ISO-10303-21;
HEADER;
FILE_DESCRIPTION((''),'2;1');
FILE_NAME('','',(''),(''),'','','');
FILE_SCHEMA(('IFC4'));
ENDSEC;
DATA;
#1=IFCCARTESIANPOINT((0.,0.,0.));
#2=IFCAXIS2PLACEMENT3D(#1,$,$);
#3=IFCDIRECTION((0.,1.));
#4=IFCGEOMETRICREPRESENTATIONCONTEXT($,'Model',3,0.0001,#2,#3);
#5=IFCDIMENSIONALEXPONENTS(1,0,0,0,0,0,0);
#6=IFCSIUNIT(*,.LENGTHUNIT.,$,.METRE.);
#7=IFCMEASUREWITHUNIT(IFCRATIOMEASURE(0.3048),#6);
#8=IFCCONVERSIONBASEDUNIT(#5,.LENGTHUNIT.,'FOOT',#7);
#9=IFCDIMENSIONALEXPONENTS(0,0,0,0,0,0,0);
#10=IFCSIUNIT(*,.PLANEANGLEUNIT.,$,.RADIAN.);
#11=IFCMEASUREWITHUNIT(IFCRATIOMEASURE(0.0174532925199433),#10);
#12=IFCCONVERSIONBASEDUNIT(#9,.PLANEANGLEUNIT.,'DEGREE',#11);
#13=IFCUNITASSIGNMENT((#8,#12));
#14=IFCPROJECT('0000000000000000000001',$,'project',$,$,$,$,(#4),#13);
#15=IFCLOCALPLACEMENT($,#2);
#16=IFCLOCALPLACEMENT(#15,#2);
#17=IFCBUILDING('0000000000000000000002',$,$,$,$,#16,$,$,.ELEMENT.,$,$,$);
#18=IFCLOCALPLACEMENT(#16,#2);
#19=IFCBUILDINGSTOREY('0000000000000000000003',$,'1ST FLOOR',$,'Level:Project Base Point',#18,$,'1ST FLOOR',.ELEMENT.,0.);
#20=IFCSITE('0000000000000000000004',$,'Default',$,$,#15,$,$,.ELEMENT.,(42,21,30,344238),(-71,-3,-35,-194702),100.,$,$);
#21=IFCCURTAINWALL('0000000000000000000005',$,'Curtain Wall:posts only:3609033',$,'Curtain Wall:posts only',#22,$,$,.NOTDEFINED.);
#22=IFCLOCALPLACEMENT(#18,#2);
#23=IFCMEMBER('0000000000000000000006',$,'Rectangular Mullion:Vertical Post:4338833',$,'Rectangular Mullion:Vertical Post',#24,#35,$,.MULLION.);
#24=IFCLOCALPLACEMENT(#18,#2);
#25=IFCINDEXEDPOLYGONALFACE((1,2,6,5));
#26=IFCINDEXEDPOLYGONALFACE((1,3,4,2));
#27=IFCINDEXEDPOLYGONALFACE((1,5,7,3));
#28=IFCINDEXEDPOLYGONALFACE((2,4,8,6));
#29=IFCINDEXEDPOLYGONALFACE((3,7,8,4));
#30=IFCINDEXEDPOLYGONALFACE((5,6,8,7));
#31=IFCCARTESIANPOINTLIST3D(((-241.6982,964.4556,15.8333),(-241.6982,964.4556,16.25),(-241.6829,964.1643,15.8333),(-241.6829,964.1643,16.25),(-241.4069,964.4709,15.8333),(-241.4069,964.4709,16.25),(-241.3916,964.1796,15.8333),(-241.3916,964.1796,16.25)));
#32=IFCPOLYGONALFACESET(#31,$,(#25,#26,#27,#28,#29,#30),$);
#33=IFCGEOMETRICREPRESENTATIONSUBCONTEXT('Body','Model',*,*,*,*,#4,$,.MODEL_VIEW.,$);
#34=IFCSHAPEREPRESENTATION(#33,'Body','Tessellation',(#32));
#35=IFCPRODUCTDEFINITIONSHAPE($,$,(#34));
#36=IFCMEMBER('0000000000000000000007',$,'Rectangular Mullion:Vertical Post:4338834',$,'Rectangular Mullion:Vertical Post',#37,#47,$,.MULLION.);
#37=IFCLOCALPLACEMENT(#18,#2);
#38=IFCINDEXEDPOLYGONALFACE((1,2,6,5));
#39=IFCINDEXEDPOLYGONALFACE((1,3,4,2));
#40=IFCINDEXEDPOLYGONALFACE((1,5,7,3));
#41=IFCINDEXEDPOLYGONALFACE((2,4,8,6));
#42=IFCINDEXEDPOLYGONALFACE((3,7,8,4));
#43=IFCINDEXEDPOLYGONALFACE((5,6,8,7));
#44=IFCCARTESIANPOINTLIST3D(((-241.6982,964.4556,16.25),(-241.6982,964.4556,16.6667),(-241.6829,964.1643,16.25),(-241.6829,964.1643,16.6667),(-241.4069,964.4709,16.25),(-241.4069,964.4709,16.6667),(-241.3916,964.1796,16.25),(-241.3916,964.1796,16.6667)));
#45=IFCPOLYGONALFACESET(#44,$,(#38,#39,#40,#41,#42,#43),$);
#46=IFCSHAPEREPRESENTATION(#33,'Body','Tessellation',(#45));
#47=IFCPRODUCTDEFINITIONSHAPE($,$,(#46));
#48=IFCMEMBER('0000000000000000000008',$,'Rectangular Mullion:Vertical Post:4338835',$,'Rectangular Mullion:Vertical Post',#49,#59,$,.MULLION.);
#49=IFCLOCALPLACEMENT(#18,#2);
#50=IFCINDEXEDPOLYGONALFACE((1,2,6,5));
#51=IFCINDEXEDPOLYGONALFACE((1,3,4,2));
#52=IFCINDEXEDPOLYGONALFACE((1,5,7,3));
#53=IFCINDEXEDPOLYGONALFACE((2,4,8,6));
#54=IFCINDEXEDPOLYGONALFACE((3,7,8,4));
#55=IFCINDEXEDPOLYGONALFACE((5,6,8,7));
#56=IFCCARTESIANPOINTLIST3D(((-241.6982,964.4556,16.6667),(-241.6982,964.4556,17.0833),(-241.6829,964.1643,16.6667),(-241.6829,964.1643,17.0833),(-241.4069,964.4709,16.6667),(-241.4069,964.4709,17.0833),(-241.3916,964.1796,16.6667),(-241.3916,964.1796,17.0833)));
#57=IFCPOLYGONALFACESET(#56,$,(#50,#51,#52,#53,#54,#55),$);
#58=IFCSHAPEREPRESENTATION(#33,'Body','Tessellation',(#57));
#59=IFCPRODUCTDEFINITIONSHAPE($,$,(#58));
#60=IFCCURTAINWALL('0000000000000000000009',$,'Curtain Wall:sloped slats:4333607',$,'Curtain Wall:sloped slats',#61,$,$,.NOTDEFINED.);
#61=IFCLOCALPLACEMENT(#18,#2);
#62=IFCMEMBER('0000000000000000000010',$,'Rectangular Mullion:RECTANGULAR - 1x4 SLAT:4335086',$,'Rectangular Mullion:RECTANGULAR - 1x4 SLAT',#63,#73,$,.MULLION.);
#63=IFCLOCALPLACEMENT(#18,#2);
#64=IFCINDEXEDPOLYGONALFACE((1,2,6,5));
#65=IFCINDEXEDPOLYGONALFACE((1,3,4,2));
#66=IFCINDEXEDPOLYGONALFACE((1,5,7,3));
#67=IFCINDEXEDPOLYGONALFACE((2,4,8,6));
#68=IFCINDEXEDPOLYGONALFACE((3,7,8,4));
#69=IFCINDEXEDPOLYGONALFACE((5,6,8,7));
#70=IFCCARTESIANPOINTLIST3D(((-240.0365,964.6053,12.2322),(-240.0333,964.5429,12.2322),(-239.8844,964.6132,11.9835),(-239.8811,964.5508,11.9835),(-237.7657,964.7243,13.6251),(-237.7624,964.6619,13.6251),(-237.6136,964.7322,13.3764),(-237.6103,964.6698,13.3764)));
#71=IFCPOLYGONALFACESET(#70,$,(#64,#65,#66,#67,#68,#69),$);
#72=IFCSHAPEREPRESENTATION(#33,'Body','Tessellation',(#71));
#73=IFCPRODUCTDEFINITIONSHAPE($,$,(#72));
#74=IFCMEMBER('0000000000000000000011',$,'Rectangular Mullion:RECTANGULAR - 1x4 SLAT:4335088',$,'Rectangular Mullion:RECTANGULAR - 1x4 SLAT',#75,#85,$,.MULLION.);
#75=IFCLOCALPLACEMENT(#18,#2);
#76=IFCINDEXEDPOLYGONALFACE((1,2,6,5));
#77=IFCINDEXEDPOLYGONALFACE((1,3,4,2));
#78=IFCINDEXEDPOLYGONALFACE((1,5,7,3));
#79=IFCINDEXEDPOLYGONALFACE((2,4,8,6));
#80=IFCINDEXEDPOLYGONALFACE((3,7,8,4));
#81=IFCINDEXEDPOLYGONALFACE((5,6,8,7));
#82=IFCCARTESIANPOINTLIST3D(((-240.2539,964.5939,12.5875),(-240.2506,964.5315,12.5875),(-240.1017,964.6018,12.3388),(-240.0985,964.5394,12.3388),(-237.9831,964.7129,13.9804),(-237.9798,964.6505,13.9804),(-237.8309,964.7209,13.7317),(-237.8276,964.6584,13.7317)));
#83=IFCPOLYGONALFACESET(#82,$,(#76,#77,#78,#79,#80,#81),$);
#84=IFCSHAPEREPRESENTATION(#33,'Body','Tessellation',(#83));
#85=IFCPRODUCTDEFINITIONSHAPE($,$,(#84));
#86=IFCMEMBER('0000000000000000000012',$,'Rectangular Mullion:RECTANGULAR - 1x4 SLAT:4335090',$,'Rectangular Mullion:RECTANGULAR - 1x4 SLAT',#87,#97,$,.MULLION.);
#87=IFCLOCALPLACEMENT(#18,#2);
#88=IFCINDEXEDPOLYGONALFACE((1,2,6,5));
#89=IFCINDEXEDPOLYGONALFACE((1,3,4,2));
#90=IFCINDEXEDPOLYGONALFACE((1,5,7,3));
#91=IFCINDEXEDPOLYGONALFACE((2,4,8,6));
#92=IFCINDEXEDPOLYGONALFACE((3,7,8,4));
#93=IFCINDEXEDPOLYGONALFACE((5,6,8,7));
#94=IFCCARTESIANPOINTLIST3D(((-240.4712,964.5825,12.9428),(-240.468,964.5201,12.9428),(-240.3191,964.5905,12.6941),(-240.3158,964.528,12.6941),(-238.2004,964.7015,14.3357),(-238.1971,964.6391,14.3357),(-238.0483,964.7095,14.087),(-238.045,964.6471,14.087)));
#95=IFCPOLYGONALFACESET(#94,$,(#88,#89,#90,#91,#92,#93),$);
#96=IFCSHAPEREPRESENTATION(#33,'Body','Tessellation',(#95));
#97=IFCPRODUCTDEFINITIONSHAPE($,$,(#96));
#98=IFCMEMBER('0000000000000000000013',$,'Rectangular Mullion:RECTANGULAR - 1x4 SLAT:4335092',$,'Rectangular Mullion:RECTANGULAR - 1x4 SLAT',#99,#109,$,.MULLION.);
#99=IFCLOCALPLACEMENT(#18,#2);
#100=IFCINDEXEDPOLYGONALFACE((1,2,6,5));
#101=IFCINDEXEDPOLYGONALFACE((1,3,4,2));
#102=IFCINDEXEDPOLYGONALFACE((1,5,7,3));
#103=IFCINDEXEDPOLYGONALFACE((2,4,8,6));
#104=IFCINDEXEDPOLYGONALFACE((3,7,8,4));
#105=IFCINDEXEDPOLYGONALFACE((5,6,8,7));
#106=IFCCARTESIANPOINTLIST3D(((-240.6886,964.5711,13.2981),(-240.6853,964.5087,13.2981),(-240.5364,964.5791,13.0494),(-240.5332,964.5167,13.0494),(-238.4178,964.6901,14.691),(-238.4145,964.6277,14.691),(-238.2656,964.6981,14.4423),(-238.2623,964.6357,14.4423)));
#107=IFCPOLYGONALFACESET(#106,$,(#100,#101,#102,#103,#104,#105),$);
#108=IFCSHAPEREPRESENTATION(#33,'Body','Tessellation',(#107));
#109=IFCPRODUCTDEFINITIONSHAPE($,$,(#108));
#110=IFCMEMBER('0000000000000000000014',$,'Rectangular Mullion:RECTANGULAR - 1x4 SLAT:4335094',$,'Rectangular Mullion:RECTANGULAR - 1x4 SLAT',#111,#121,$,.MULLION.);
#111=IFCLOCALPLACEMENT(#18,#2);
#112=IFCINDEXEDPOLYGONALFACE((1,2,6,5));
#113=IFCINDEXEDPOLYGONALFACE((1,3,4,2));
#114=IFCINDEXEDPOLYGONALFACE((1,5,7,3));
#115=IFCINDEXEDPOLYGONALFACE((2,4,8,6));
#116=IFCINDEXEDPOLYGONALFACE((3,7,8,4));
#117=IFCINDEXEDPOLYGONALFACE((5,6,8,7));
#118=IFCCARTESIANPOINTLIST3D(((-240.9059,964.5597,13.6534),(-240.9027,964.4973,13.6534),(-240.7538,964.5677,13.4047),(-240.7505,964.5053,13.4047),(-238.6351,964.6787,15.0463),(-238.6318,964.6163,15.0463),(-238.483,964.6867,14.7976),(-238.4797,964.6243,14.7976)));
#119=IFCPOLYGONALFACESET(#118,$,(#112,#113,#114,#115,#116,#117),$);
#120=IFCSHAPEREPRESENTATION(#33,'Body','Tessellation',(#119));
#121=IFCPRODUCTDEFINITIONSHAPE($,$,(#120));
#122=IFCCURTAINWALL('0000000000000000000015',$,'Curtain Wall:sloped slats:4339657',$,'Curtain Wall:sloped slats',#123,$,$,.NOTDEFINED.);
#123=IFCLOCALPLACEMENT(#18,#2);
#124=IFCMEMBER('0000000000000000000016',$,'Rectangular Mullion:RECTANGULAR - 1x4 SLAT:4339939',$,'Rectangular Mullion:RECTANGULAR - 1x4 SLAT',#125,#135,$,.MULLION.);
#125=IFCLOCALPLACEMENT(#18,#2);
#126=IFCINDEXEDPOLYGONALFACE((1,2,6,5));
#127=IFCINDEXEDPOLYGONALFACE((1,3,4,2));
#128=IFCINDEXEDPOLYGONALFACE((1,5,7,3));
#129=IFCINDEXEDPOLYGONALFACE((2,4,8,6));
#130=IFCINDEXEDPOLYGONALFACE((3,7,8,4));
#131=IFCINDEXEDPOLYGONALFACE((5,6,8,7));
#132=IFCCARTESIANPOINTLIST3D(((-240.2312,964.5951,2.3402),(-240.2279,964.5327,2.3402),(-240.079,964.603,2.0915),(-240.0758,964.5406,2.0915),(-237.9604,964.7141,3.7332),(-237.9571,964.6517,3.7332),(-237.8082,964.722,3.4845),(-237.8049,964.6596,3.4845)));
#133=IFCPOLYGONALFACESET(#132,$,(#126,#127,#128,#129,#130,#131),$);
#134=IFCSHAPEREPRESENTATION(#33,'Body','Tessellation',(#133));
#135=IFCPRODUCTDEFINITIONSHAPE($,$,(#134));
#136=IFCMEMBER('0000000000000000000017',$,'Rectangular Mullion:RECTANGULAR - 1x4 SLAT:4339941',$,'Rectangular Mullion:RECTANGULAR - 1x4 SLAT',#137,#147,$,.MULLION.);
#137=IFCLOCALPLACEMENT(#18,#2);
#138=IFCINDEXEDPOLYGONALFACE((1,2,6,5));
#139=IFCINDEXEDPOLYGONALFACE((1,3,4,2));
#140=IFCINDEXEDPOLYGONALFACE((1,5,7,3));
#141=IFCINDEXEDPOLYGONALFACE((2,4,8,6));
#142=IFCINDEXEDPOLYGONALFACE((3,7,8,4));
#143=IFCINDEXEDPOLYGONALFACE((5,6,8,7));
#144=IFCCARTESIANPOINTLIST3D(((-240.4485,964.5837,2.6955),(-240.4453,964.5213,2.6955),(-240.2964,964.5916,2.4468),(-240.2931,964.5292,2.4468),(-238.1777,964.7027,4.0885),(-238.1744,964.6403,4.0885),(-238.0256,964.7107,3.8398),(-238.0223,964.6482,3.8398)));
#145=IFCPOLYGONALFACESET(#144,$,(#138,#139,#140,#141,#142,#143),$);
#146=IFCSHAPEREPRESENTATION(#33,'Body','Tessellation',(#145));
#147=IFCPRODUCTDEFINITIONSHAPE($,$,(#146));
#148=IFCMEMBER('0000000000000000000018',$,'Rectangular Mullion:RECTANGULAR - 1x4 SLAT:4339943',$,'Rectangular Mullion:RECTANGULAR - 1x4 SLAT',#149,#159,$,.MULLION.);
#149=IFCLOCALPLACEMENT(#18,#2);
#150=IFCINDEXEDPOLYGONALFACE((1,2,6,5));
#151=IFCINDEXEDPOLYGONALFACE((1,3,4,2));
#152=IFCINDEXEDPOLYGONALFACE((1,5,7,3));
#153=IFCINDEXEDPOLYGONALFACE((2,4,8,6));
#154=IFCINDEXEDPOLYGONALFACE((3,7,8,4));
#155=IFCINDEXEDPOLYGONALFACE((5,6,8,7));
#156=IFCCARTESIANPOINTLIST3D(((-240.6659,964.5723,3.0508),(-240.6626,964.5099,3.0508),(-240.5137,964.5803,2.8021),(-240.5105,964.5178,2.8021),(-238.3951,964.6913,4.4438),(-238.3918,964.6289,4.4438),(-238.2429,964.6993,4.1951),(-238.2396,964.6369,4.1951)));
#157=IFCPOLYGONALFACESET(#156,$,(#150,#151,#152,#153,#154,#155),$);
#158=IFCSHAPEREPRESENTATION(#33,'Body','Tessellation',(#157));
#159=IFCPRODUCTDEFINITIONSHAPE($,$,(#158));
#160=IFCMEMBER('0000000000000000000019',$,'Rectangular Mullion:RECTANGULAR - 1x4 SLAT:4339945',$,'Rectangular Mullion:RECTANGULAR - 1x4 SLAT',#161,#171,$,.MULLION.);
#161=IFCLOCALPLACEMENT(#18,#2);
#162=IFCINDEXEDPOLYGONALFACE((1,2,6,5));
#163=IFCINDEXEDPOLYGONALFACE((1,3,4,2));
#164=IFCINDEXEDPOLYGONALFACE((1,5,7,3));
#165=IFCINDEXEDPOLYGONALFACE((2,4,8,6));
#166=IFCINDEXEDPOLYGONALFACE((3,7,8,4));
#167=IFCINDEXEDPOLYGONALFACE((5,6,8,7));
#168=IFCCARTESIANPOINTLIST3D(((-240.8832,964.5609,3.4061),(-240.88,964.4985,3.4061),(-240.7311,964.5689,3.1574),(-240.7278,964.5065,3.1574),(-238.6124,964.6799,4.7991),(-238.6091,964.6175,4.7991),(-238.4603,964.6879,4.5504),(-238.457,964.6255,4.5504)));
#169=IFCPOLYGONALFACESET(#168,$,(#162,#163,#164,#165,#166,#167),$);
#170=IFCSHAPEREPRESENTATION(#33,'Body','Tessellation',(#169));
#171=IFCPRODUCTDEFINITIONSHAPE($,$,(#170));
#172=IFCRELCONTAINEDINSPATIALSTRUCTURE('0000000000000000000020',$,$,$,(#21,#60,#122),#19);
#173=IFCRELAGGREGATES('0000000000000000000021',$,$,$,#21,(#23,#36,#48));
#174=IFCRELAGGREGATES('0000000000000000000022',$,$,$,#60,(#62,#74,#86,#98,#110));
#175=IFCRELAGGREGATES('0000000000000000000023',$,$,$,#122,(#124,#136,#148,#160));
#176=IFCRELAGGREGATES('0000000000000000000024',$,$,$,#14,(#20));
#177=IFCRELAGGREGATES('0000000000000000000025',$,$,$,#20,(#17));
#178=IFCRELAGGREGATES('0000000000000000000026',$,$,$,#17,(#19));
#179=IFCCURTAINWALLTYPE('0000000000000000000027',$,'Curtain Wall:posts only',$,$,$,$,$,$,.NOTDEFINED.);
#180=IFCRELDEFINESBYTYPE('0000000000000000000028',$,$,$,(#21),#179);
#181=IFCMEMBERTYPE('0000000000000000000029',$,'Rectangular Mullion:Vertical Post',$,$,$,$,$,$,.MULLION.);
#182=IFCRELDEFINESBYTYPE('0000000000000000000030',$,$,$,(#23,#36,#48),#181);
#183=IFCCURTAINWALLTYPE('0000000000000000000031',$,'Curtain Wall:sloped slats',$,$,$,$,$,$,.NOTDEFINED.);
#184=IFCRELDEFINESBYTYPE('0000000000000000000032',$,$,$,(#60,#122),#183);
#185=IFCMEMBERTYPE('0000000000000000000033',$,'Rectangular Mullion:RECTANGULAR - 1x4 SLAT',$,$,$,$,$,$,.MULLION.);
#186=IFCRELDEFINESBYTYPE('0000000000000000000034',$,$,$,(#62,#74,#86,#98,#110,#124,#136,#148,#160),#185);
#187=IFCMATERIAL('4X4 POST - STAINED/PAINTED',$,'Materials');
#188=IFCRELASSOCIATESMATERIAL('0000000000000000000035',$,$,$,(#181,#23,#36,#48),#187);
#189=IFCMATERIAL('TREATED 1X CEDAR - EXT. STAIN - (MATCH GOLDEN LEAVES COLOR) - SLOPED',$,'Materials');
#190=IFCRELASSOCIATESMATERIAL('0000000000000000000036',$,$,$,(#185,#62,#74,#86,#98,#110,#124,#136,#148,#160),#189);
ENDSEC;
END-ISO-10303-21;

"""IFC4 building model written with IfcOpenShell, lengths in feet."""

from ifc_helpers import new_model, entity, si_unit, converted_unit, direction, frame, frame_2d, origin, origin_2d_with_axis, place, context, subcontext, project, spatial, rectangle, extrude, source, transform, mapped, material, material_profile, profile_set, profile_usage, type_object, type_shapes, element, aggregate, save


model = new_model("IFC4")

# Units and contexts
model_context = context("Model", 3, precision=0.0001, world=origin(), true_north=direction((0.0, 1.0)))
body_context = subcontext(model_context, "Body", "Model", "MODEL_VIEW")
ifc_project = project(units=[converted_unit("LENGTHUNIT", "FOOT", entity("IfcRatioMeasure", 0.3048), si_unit("LENGTHUNIT", "METRE"), dimensions=[1, 0, 0, 0, 0, 0, 0]), converted_unit("PLANEANGLEUNIT", "DEGREE", entity("IfcRatioMeasure", 0.0174532925199433), si_unit("PLANEANGLEUNIT", "RADIAN"), dimensions=[0, 0, 0, 0, 0, 0, 0])], contexts=[model_context])

# Site, building, storey
site_placement = place(None, origin())
site = spatial("IfcSite", under=ifc_project, at=site_placement, Name="Default", CompositionType="ELEMENT", RefLatitude=(42, 21, 30, 344238), RefLongitude=(-71, -3, -35, -194702), RefElevation=100.0)
building_placement = place(site_placement, origin())
building = spatial("IfcBuilding", under=site, at=building_placement, CompositionType="ELEMENT")
storey_placement = place(building_placement, origin())
storey = spatial("IfcBuildingStorey", under=building, at=storey_placement, Name="1ST FLOOR", ObjectType="Level:Project Base Point", LongName="1ST FLOOR", CompositionType="ELEMENT", Elevation=0.0)

# Curtain walls, members
curtain_wall_type_1 = type_object("IfcCurtainWallType", Name="Curtain Wall:posts only", PredefinedType="NOTDEFINED")
curtain_wall_1_placement = place(storey_placement, origin())
curtain_wall_1 = element("IfcCurtainWall", 1, at=curtain_wall_1_placement, inside=storey, type_object=curtain_wall_type_1, Name="Curtain Wall:posts only:3609033", ObjectType="Curtain Wall:posts only", PredefinedType="NOTDEFINED")
ifc_material_1 = material(Name="4X4 POST - STAINED/PAINTED", Category="Materials")
ifc_material_profile_1 = material_profile(ifc_material_1, rectangle(XDim=0.2917, YDim=0.2917, at=origin_2d_with_axis()), Name="Vertical Post")
ifc_profile_set_1 = profile_set([ifc_material_profile_1], Name="Vertical Post")
member_type_1 = type_object("IfcMemberType", Name="Rectangular Mullion:Vertical Post", PredefinedType="MULLION", material=ifc_profile_set_1)
shared_shape_1 = source(origin(), body_context, "Body", "SweptSolid", [
    extrude(rectangle(XDim=0.2917, YDim=0.2917, at=origin_2d_with_axis()), frame((0.0, -0.2083, -0.4167), z_axis=(0.0, 0.0, 1.0), x_axis=(0.0, -1.0, 0.0)), (0.0, 0.0, 1.0), 0.4167),
])
type_shapes(member_type_1, [shared_shape_1])
ifc_profile_usage_1 = profile_usage(ifc_profile_set_1)
member_1_placement = place(storey_placement, frame((-241.5558, 964.5256, 15.8333), z_axis=(0.0, 0.0, -1.0), x_axis=(-0.99863, -0.052336, 0.0)))
member_1 = element("IfcMember", 2, at=member_1_placement, type_object=member_type_1, material=ifc_profile_usage_1, Name="Rectangular Mullion:Vertical Post:4338833", ObjectType="Rectangular Mullion:Vertical Post", PredefinedType="MULLION", context=body_context, shape_type="MappedRepresentation", body=[
    mapped(shared_shape_1, transform((0.0, 0.0, 0.0), scale=1.0)),
])
ifc_profile_usage_2 = profile_usage(ifc_profile_set_1)
member_2_placement = place(storey_placement, frame((-241.5558, 964.5256, 16.25), z_axis=(0.0, 0.0, -1.0), x_axis=(-0.99863, -0.052336, 0.0)))
member_2 = element("IfcMember", 3, at=member_2_placement, type_object=member_type_1, material=ifc_profile_usage_2, Name="Rectangular Mullion:Vertical Post:4338834", ObjectType="Rectangular Mullion:Vertical Post", PredefinedType="MULLION", context=body_context, shape_type="MappedRepresentation", body=[
    mapped(shared_shape_1, transform((0.0, 0.0, 0.0), scale=1.0)),
])
ifc_profile_usage_3 = profile_usage(ifc_profile_set_1)
member_3_placement = place(storey_placement, frame((-241.5558, 964.5256, 16.6667), z_axis=(0.0, 0.0, -1.0), x_axis=(-0.99863, -0.052336, 0.0)))
member_3 = element("IfcMember", 4, at=member_3_placement, type_object=member_type_1, material=ifc_profile_usage_3, Name="Rectangular Mullion:Vertical Post:4338835", ObjectType="Rectangular Mullion:Vertical Post", PredefinedType="MULLION", context=body_context, shape_type="MappedRepresentation", body=[
    mapped(shared_shape_1, transform((0.0, 0.0, 0.0), scale=1.0)),
])
aggregate(curtain_wall_1, [member_1, member_2, member_3])
curtain_wall_type_2 = type_object("IfcCurtainWallType", Name="Curtain Wall:sloped slats", PredefinedType="NOTDEFINED")
curtain_wall_2_placement = place(storey_placement, origin())
curtain_wall_2 = element("IfcCurtainWall", 5, at=curtain_wall_2_placement, inside=storey, type_object=curtain_wall_type_2, Name="Curtain Wall:sloped slats:4333607", ObjectType="Curtain Wall:sloped slats", PredefinedType="NOTDEFINED")
ifc_material_2 = material(Name="TREATED 1X CEDAR - EXT. STAIN - (MATCH GOLDEN LEAVES COLOR) - SLOPED", Category="Materials")
ifc_material_profile_2 = material_profile(ifc_material_2, rectangle(XDim=0.0625, YDim=0.2917, at=frame_2d((0.0, 0.0), x_axis=(1.0, 0.0))), Name="RECTANGULAR - 1x4 SLAT")
ifc_profile_set_2 = profile_set([ifc_material_profile_2], Name="RECTANGULAR - 1x4 SLAT")
ifc_profile_usage_4 = profile_usage(ifc_profile_set_2)
member_type_2 = type_object("IfcMemberType", Name="Rectangular Mullion:RECTANGULAR - 1x4 SLAT", PredefinedType="MULLION", material=ifc_profile_set_2)
shared_shape_2 = source(origin(), body_context, "Body", "SweptSolid", [
    extrude(rectangle(XDim=0.0625, YDim=0.2917, at=frame_2d((0.0, 0.0), x_axis=(1.0, 0.0))), frame((0.0, 0.0, -2.6667), z_axis=(0.0, 0.0, 1.0), x_axis=(0.0, -1.0, 0.0)), (0.0, 0.0, 1.0), 2.6667),
])
type_shapes(member_type_2, [shared_shape_2])
member_4_placement = place(storey_placement, frame((-239.9588, 964.578, 12.1078), z_axis=(-0.851559, -0.044628, -0.522356), x_axis=(-0.52164, -0.027338, 0.852727)))
member_4 = element("IfcMember", 6, at=member_4_placement, type_object=member_type_2, material=ifc_profile_usage_4, Name="Rectangular Mullion:RECTANGULAR - 1x4 SLAT:4335086", ObjectType="Rectangular Mullion:RECTANGULAR - 1x4 SLAT", PredefinedType="MULLION", context=body_context, shape_type="MappedRepresentation", body=[
    mapped(shared_shape_2, transform((0.0, 0.0, 0.0), scale=1.0)),
])
ifc_profile_usage_5 = profile_usage(ifc_profile_set_2)
member_5_placement = place(storey_placement, frame((-240.1762, 964.5667, 12.4631), z_axis=(-0.851559, -0.044628, -0.522356), x_axis=(-0.52164, -0.027338, 0.852727)))
member_5 = element("IfcMember", 7, at=member_5_placement, type_object=member_type_2, material=ifc_profile_usage_5, Name="Rectangular Mullion:RECTANGULAR - 1x4 SLAT:4335088", ObjectType="Rectangular Mullion:RECTANGULAR - 1x4 SLAT", PredefinedType="MULLION", context=body_context, shape_type="MappedRepresentation", body=[
    mapped(shared_shape_2, transform((0.0, 0.0, 0.0), scale=1.0)),
])
ifc_profile_usage_6 = profile_usage(ifc_profile_set_2)
member_6_placement = place(storey_placement, frame((-240.3935, 964.5553, 12.8184), z_axis=(-0.851559, -0.044628, -0.522356), x_axis=(-0.52164, -0.027338, 0.852727)))
member_6 = element("IfcMember", 8, at=member_6_placement, type_object=member_type_2, material=ifc_profile_usage_6, Name="Rectangular Mullion:RECTANGULAR - 1x4 SLAT:4335090", ObjectType="Rectangular Mullion:RECTANGULAR - 1x4 SLAT", PredefinedType="MULLION", context=body_context, shape_type="MappedRepresentation", body=[
    mapped(shared_shape_2, transform((0.0, 0.0, 0.0), scale=1.0)),
])
ifc_profile_usage_7 = profile_usage(ifc_profile_set_2)
member_7_placement = place(storey_placement, frame((-240.6109, 964.5439, 13.1737), z_axis=(-0.851559, -0.044628, -0.522356), x_axis=(-0.52164, -0.027338, 0.852727)))
member_7 = element("IfcMember", 9, at=member_7_placement, type_object=member_type_2, material=ifc_profile_usage_7, Name="Rectangular Mullion:RECTANGULAR - 1x4 SLAT:4335092", ObjectType="Rectangular Mullion:RECTANGULAR - 1x4 SLAT", PredefinedType="MULLION", context=body_context, shape_type="MappedRepresentation", body=[
    mapped(shared_shape_2, transform((0.0, 0.0, 0.0), scale=1.0)),
])
ifc_profile_usage_8 = profile_usage(ifc_profile_set_2)
member_8_placement = place(storey_placement, frame((-240.8282, 964.5325, 13.529), z_axis=(-0.851559, -0.044628, -0.522356), x_axis=(-0.52164, -0.027338, 0.852727)))
member_8 = element("IfcMember", 10, at=member_8_placement, type_object=member_type_2, material=ifc_profile_usage_8, Name="Rectangular Mullion:RECTANGULAR - 1x4 SLAT:4335094", ObjectType="Rectangular Mullion:RECTANGULAR - 1x4 SLAT", PredefinedType="MULLION", context=body_context, shape_type="MappedRepresentation", body=[
    mapped(shared_shape_2, transform((0.0, 0.0, 0.0), scale=1.0)),
])
aggregate(curtain_wall_2, [member_4, member_5, member_6, member_7, member_8])
curtain_wall_3_placement = place(storey_placement, origin())
curtain_wall_3 = element("IfcCurtainWall", 11, at=curtain_wall_3_placement, inside=storey, type_object=curtain_wall_type_2, Name="Curtain Wall:sloped slats:4339657", ObjectType="Curtain Wall:sloped slats", PredefinedType="NOTDEFINED")
ifc_profile_usage_9 = profile_usage(ifc_profile_set_2)
member_9_placement = place(storey_placement, frame((-240.1535, 964.5678, 2.2159), z_axis=(-0.851559, -0.044628, -0.522356), x_axis=(-0.52164, -0.027338, 0.852727)))
member_9 = element("IfcMember", 12, at=member_9_placement, type_object=member_type_2, material=ifc_profile_usage_9, Name="Rectangular Mullion:RECTANGULAR - 1x4 SLAT:4339939", ObjectType="Rectangular Mullion:RECTANGULAR - 1x4 SLAT", PredefinedType="MULLION", context=body_context, shape_type="MappedRepresentation", body=[
    mapped(shared_shape_2, transform((0.0, 0.0, 0.0), scale=1.0)),
])
ifc_profile_usage_10 = profile_usage(ifc_profile_set_2)
member_10_placement = place(storey_placement, frame((-240.3708, 964.5565, 2.5712), z_axis=(-0.851559, -0.044628, -0.522356), x_axis=(-0.52164, -0.027338, 0.852727)))
member_10 = element("IfcMember", 13, at=member_10_placement, type_object=member_type_2, material=ifc_profile_usage_10, Name="Rectangular Mullion:RECTANGULAR - 1x4 SLAT:4339941", ObjectType="Rectangular Mullion:RECTANGULAR - 1x4 SLAT", PredefinedType="MULLION", context=body_context, shape_type="MappedRepresentation", body=[
    mapped(shared_shape_2, transform((0.0, 0.0, 0.0), scale=1.0)),
])
ifc_profile_usage_11 = profile_usage(ifc_profile_set_2)
member_11_placement = place(storey_placement, frame((-240.5882, 964.5451, 2.9265), z_axis=(-0.851559, -0.044628, -0.522356), x_axis=(-0.52164, -0.027338, 0.852727)))
member_11 = element("IfcMember", 14, at=member_11_placement, type_object=member_type_2, material=ifc_profile_usage_11, Name="Rectangular Mullion:RECTANGULAR - 1x4 SLAT:4339943", ObjectType="Rectangular Mullion:RECTANGULAR - 1x4 SLAT", PredefinedType="MULLION", context=body_context, shape_type="MappedRepresentation", body=[
    mapped(shared_shape_2, transform((0.0, 0.0, 0.0), scale=1.0)),
])
ifc_profile_usage_12 = profile_usage(ifc_profile_set_2)
member_12_placement = place(storey_placement, frame((-240.8055, 964.5337, 3.2818), z_axis=(-0.851559, -0.044628, -0.522356), x_axis=(-0.52164, -0.027338, 0.852727)))
member_12 = element("IfcMember", 15, at=member_12_placement, type_object=member_type_2, material=ifc_profile_usage_12, Name="Rectangular Mullion:RECTANGULAR - 1x4 SLAT:4339945", ObjectType="Rectangular Mullion:RECTANGULAR - 1x4 SLAT", PredefinedType="MULLION", context=body_context, shape_type="MappedRepresentation", body=[
    mapped(shared_shape_2, transform((0.0, 0.0, 0.0), scale=1.0)),
])
aggregate(curtain_wall_3, [member_9, member_10, member_11, member_12])

save(model, "model.ifc")
